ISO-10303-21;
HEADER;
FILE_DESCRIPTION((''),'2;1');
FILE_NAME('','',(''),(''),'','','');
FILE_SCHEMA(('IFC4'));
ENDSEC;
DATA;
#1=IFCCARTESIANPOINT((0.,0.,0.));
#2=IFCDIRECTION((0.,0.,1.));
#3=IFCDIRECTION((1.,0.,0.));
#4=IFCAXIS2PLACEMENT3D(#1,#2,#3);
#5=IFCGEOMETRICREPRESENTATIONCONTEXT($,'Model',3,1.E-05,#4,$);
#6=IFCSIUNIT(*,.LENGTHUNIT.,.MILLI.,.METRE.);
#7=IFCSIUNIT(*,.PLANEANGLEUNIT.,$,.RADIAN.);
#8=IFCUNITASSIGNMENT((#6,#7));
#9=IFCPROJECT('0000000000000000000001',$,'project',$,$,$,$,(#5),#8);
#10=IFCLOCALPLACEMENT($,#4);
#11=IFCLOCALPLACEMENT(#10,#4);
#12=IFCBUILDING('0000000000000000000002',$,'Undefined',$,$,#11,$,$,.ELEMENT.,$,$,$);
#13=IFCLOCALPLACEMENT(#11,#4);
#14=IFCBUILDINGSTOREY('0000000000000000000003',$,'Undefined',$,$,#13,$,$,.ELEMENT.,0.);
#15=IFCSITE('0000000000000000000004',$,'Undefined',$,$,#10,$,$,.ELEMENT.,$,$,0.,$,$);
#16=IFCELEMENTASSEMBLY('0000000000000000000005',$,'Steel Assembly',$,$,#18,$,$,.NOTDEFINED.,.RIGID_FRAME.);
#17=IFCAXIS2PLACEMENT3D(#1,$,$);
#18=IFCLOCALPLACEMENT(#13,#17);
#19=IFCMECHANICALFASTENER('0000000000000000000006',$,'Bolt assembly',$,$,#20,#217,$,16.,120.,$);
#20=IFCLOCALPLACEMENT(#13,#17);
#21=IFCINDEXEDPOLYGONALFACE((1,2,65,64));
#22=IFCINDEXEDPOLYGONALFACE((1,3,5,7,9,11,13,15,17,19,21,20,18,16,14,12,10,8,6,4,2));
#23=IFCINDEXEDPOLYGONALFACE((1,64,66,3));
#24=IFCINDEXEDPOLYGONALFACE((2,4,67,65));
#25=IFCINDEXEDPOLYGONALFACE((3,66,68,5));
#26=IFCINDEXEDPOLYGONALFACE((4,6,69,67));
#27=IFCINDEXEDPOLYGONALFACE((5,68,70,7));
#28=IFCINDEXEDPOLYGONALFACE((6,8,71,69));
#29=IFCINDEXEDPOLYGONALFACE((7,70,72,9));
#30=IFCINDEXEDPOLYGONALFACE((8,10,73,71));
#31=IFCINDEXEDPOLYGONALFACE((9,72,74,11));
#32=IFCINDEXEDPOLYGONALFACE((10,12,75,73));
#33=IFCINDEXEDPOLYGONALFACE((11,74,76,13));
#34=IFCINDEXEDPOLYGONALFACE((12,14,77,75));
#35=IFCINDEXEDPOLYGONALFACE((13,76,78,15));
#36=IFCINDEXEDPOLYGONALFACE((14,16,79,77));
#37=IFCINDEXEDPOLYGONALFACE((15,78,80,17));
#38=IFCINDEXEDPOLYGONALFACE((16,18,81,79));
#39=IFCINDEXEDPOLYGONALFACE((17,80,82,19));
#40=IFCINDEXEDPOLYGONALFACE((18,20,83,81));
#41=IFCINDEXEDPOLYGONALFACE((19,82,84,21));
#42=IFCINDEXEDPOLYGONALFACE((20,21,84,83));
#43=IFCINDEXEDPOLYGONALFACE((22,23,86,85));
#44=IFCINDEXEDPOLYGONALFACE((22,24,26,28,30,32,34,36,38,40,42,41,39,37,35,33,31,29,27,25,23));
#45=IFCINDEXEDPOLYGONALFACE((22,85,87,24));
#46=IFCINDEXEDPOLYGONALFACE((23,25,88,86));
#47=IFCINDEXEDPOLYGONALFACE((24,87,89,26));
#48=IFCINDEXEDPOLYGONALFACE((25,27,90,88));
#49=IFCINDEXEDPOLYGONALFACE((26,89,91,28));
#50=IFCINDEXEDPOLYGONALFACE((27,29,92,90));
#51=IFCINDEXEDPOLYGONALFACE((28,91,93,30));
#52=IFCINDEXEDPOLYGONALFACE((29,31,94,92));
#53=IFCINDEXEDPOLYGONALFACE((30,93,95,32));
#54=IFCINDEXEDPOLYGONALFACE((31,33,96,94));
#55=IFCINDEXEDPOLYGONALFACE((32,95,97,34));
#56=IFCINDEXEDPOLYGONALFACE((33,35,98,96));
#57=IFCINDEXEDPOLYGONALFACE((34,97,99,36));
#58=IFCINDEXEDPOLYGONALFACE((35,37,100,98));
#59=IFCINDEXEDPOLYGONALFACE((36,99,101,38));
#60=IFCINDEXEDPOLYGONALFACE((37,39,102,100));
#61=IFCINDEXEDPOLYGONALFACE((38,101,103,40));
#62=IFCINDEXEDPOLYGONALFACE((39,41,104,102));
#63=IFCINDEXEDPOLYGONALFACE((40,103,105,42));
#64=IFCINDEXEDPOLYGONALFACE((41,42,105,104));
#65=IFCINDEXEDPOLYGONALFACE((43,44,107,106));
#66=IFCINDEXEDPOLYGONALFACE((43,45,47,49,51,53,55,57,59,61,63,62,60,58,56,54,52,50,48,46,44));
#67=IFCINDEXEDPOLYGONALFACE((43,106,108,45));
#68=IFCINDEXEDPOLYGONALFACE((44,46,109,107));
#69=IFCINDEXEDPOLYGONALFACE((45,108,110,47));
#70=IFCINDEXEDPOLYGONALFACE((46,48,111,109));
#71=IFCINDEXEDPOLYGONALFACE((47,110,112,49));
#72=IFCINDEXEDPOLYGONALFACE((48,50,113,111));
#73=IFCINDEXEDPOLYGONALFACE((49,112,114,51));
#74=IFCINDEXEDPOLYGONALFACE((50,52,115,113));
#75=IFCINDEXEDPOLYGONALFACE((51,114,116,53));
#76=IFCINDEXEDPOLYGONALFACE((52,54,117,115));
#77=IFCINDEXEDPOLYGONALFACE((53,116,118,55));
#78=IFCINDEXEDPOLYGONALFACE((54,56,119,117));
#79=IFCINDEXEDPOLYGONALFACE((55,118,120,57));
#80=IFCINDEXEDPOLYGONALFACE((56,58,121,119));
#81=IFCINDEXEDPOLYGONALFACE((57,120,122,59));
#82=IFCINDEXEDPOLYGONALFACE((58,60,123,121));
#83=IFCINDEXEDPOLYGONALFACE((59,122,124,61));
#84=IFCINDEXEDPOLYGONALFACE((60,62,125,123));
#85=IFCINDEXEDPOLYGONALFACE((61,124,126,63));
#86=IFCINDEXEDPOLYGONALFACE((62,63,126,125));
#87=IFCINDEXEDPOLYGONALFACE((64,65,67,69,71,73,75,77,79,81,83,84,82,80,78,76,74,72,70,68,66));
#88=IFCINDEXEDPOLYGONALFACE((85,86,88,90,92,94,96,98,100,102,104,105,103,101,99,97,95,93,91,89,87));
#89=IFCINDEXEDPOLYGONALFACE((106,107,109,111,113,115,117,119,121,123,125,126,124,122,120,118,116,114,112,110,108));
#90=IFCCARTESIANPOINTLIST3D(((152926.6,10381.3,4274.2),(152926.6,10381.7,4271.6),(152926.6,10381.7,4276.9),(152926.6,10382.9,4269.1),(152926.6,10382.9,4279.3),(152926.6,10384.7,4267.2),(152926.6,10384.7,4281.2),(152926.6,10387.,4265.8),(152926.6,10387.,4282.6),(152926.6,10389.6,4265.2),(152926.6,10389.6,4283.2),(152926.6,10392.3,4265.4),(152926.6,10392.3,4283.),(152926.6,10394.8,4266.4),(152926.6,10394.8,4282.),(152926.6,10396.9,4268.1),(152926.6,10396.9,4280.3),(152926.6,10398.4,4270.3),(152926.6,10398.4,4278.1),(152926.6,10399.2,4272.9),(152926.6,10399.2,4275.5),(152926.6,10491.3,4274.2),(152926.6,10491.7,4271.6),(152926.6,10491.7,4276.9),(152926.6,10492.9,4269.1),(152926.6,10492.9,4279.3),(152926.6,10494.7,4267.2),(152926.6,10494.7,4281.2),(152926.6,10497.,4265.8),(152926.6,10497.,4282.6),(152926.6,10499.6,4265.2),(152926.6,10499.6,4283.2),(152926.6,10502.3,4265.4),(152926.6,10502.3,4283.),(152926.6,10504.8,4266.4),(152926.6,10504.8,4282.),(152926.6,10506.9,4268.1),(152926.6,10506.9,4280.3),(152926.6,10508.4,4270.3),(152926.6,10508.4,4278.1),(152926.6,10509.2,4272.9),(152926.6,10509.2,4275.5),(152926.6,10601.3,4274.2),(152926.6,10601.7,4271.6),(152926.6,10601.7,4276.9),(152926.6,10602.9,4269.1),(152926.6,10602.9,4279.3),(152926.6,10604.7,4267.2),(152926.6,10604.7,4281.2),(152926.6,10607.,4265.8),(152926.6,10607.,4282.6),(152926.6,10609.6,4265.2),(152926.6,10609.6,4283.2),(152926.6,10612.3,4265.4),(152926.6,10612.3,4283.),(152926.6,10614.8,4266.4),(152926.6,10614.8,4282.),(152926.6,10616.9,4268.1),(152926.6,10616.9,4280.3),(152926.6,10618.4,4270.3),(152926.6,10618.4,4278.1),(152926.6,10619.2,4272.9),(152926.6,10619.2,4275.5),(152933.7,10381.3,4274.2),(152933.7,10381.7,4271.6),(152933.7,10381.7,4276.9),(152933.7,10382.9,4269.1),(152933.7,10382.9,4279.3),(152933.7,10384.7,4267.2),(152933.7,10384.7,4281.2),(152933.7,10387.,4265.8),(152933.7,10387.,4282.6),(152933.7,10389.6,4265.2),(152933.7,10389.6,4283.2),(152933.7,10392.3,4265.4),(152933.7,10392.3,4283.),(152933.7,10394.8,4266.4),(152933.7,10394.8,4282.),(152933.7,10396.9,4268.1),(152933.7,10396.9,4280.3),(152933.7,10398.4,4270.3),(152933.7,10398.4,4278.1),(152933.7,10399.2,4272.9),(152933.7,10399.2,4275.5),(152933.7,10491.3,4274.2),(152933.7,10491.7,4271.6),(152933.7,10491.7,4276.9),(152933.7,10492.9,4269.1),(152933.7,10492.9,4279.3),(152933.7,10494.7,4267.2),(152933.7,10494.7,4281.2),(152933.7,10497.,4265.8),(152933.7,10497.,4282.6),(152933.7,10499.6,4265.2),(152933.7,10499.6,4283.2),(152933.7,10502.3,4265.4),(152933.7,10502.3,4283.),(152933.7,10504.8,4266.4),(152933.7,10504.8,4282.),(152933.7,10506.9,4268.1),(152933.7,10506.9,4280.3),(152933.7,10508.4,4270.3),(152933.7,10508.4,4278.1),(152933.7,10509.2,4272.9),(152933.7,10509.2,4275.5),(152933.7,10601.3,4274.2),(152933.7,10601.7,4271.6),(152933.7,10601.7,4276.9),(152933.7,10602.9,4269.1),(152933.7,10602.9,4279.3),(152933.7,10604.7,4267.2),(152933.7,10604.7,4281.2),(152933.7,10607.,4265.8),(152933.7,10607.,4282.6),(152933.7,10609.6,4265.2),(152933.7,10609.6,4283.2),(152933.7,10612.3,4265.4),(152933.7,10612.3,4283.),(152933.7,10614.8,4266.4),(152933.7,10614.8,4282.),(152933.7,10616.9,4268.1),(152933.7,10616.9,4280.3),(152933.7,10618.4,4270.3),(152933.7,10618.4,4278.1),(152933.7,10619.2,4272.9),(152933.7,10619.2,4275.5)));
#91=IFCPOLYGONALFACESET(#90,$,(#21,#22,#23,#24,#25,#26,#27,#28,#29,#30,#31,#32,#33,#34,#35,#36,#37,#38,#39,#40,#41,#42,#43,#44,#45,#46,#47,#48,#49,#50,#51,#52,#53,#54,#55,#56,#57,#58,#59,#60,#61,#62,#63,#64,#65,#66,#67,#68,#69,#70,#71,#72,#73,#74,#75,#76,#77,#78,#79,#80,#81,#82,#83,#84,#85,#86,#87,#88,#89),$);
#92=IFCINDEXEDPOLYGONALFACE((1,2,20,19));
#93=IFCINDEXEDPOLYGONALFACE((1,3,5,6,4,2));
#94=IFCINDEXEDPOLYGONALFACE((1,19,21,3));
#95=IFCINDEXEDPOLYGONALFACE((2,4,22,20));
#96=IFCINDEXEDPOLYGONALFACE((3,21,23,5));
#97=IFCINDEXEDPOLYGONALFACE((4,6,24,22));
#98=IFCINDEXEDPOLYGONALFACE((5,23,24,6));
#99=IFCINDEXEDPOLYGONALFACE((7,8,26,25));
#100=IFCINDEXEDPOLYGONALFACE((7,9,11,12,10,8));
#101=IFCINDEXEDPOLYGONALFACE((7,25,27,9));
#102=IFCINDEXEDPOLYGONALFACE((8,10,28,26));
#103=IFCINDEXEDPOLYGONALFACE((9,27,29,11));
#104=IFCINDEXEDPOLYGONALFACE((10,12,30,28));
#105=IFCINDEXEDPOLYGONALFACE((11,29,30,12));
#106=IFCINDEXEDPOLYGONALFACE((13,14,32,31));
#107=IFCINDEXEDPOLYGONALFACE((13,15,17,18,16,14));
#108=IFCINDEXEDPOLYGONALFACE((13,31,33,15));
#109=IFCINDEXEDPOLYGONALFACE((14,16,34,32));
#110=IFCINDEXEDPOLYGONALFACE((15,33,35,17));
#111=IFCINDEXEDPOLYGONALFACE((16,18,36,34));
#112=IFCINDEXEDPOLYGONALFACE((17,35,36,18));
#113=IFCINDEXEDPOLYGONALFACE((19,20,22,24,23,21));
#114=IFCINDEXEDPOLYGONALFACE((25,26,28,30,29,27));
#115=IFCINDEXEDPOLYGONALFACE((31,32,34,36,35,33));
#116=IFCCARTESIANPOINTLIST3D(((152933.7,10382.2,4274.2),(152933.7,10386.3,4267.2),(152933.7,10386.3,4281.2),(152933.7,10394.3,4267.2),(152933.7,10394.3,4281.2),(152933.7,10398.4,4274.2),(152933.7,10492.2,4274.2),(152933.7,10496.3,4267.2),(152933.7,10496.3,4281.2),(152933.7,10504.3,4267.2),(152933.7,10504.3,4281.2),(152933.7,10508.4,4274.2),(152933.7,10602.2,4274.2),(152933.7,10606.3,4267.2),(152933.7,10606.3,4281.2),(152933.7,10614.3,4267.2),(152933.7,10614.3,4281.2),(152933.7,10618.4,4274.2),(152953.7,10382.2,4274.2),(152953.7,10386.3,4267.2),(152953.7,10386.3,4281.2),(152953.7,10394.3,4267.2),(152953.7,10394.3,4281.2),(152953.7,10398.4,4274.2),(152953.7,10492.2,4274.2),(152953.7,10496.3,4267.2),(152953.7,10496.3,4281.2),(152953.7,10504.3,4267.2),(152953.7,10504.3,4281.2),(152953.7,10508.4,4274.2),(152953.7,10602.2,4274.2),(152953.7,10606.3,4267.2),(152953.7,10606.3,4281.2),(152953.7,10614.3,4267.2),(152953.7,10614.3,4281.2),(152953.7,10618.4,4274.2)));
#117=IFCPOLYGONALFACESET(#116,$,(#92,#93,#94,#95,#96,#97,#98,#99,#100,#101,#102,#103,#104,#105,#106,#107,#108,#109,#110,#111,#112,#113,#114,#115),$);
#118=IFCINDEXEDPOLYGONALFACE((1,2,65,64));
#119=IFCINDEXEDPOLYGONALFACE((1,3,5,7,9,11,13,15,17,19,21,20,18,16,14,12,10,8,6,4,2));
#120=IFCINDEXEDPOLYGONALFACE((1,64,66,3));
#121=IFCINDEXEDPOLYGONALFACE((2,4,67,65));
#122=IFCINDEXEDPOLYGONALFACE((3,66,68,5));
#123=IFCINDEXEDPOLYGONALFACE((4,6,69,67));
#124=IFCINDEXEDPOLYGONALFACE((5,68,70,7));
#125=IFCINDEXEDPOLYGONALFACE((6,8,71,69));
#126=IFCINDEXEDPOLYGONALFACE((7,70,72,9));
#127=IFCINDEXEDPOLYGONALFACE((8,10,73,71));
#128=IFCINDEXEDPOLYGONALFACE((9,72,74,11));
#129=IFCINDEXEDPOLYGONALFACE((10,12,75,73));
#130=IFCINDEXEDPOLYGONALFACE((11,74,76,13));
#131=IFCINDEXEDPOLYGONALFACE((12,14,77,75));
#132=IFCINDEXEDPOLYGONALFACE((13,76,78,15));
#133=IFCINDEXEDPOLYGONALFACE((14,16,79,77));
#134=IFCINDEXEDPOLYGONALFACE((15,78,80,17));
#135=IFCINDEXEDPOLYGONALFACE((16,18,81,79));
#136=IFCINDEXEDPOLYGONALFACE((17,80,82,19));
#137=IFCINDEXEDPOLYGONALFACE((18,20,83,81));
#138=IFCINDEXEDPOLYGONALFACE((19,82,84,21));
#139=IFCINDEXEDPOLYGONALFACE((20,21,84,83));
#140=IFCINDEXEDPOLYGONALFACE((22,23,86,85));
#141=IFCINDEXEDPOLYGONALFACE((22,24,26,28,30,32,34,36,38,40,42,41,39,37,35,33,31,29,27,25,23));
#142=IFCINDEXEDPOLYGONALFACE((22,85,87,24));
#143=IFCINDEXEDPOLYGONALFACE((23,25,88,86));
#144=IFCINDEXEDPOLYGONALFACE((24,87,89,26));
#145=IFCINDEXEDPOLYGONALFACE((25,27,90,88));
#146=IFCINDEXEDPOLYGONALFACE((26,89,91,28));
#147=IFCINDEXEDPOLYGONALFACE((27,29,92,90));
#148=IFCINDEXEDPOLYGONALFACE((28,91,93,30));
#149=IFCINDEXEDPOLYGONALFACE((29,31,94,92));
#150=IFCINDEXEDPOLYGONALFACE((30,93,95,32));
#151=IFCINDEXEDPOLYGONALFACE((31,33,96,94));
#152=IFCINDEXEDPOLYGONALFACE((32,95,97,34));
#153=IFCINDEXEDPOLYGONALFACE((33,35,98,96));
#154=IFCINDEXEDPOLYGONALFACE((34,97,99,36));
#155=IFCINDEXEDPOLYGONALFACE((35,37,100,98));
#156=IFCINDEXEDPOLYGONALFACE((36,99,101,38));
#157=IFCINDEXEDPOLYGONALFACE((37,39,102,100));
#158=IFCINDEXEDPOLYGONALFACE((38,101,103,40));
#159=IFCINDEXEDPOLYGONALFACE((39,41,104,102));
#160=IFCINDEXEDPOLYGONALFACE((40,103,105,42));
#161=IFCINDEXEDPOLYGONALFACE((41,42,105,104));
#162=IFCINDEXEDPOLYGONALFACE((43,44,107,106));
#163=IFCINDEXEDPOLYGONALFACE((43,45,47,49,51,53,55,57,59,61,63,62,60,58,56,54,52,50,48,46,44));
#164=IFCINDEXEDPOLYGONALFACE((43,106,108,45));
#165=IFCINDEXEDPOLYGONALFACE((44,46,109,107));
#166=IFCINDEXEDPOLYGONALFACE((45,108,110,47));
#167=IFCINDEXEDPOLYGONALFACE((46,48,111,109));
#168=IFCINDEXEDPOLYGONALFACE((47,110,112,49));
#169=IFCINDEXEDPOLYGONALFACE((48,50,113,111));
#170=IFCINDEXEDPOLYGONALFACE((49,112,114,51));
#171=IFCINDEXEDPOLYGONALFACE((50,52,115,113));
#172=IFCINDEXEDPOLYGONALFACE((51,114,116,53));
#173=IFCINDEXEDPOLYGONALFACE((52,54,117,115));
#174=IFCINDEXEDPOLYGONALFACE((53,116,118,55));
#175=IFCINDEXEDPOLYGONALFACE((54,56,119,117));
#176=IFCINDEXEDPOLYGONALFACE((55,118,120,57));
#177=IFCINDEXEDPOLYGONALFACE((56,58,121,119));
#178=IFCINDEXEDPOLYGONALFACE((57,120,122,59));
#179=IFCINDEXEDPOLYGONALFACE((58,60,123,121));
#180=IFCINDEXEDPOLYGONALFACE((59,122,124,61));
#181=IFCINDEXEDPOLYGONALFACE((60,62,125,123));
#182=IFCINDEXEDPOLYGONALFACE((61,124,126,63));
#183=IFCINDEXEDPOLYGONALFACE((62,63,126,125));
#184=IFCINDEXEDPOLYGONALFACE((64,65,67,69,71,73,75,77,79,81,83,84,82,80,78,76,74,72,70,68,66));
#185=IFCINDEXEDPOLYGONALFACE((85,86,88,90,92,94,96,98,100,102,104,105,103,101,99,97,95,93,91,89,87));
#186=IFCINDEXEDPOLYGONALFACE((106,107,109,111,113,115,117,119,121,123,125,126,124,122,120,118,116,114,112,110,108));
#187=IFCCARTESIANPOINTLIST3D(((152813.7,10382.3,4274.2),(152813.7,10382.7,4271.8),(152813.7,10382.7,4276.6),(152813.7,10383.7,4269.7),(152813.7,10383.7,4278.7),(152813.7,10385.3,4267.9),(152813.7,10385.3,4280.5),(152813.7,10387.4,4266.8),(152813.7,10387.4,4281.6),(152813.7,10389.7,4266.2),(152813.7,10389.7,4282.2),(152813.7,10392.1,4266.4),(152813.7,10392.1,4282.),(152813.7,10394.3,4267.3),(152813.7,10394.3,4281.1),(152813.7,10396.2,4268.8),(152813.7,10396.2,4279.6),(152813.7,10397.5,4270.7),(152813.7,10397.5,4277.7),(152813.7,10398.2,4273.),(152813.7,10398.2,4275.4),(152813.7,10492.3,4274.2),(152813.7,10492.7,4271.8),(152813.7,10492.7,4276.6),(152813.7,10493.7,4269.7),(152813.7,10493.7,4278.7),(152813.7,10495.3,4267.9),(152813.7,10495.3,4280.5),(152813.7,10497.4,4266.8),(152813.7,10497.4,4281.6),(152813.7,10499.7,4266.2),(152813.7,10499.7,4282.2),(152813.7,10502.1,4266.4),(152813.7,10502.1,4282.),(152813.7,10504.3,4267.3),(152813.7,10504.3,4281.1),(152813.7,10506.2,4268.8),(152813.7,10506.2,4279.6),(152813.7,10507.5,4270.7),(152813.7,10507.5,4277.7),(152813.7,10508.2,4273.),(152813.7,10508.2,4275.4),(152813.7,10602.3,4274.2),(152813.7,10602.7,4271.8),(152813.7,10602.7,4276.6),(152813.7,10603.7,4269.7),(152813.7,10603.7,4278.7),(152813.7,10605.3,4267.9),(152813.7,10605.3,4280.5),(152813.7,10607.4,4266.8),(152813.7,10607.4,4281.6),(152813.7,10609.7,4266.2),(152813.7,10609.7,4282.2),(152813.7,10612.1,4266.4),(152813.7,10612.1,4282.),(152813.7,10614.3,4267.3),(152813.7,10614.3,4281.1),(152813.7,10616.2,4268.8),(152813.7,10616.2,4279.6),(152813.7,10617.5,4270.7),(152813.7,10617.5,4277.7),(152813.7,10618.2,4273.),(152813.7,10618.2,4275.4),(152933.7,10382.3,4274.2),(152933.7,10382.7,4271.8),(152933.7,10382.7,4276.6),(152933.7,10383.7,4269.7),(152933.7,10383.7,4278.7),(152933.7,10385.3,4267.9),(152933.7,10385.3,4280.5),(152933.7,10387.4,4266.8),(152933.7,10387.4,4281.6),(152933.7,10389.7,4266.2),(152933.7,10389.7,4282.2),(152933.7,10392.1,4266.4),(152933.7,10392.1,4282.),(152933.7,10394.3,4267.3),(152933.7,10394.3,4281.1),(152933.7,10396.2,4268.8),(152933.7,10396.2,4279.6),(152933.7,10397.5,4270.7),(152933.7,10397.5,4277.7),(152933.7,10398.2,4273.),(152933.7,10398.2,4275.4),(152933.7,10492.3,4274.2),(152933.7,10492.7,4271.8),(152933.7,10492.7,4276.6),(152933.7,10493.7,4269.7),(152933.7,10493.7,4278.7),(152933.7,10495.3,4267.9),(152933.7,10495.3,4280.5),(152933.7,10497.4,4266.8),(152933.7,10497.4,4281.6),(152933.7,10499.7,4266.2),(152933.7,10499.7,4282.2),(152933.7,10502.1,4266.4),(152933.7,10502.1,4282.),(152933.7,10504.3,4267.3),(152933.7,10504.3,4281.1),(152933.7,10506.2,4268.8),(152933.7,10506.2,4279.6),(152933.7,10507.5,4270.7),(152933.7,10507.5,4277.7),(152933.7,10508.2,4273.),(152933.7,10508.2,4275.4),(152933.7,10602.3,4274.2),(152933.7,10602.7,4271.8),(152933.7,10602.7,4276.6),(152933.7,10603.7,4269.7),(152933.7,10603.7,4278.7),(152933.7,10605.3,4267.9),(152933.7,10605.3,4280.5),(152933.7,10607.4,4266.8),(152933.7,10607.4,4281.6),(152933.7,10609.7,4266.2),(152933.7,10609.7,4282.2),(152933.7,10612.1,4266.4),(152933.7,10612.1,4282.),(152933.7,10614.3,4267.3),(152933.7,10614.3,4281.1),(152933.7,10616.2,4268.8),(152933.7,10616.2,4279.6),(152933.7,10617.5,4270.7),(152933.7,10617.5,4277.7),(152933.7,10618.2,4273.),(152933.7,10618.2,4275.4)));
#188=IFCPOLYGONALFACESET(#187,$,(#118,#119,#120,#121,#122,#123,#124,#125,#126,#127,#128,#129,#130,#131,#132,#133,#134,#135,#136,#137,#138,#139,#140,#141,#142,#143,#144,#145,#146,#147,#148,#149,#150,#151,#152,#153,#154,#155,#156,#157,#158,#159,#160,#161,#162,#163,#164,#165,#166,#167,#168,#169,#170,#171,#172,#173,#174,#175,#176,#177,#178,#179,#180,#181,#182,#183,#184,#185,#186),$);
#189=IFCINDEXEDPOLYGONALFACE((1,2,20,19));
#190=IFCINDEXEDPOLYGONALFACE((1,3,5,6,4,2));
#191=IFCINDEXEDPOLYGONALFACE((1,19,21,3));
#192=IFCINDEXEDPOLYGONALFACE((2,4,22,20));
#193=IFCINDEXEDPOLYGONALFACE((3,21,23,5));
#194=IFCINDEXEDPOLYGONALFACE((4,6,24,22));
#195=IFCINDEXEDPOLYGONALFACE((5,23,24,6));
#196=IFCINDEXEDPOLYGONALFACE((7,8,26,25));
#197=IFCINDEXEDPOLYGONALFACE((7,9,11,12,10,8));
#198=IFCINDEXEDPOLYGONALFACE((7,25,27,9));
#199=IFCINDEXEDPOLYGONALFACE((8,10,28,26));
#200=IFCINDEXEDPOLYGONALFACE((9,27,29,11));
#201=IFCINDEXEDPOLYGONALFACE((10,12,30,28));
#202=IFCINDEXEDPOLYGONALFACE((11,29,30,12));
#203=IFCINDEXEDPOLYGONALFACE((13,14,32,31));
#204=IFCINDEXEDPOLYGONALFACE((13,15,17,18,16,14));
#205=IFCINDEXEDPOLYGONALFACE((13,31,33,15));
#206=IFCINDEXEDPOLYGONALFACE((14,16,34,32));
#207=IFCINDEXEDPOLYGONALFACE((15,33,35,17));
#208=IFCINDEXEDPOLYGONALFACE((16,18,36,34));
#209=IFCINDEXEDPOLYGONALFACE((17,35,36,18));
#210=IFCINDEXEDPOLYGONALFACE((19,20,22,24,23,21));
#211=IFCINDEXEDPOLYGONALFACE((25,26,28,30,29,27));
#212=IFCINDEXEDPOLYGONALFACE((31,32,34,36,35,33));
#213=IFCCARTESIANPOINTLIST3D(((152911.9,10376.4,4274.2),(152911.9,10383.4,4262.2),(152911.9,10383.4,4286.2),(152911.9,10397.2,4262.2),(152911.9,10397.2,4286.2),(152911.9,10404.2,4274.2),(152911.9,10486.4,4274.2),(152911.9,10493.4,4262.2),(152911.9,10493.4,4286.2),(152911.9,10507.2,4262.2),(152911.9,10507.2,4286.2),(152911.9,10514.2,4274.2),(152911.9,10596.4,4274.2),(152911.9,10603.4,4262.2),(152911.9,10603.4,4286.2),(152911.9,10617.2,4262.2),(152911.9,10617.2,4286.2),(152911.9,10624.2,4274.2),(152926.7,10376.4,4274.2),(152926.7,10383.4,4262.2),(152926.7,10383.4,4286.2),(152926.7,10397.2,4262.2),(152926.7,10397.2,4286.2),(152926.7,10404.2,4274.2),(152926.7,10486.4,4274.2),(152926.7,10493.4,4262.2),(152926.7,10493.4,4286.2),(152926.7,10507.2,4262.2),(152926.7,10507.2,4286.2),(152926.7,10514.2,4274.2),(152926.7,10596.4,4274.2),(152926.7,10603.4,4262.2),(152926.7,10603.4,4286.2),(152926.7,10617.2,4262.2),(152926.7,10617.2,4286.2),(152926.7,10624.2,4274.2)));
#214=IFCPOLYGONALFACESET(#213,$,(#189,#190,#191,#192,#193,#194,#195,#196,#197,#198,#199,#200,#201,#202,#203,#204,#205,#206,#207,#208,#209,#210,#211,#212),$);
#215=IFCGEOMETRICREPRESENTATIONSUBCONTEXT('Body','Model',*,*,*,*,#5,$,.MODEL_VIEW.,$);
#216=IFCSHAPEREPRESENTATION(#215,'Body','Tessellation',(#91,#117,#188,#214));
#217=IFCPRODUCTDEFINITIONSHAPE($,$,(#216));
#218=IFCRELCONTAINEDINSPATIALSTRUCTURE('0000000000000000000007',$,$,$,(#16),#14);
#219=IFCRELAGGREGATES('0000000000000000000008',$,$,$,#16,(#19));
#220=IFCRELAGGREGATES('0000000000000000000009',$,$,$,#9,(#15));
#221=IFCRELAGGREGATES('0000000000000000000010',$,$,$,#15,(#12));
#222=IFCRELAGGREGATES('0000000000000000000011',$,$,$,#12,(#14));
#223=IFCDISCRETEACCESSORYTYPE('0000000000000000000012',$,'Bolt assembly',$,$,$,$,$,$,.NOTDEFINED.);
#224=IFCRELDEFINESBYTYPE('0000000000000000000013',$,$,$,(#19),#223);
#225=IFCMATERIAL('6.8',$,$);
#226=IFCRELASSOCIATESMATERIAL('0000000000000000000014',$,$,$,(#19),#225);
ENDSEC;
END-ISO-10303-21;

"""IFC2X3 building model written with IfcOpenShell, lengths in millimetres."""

from ifc_helpers import new_model, si_unit, frame, origin_with_axes, origin_2d_with_axis, place, context, subcontext, project, spatial, polyline, circle, outline, extrude, source, transform, mapped, material, type_object, element, aggregate, save


model = new_model("IFC2X3")

# Units and contexts
model_context = context("Model", 3, precision=1e-05, world=origin_with_axes())
body_context = subcontext(model_context, "Body", "Model", "MODEL_VIEW")
ifc_project = project(units=[si_unit("LENGTHUNIT", "METRE", prefix="MILLI"), si_unit("PLANEANGLEUNIT", "RADIAN")], contexts=[model_context])

# Site, building, storey
site_placement = place(None, origin_with_axes())
site = spatial("IfcSite", under=ifc_project, at=site_placement, Name="Undefined", CompositionType="ELEMENT", RefElevation=0.0)
building_placement = place(site_placement, origin_with_axes())
building = spatial("IfcBuilding", under=site, at=building_placement, Name="Undefined", CompositionType="ELEMENT")
storey_placement = place(building_placement, origin_with_axes())
storey = spatial("IfcBuildingStorey", under=building, at=storey_placement, Name="Undefined", CompositionType="ELEMENT", Elevation=0.0)

# Element assembly
assembly_1_placement = place(storey_placement, origin_with_axes())
assembly_1 = element("IfcElementAssembly", 1, at=assembly_1_placement, inside=storey, Name="Steel Assembly", AssemblyPlace="NOTDEFINED", PredefinedType="RIGID_FRAME")

# Mechanical fastener
discrete_accessory_type_1 = type_object("IfcDiscreteAccessoryType", Name="Bolt assembly")
ifc_material_1 = material(Name="6.8")
shared_shape_1 = source(origin_with_axes(), body_context, "Body", "SweptSolid", [
    extrude(circle(Radius=9.0, at=origin_2d_with_axis()), frame((0.0, -2.5, 0.0), z_axis=(0.0, 1.0, 0.0), x_axis=(1.0, 0.0, 0.0)), (0.0, 0.0, 1.0), 7.1),
    extrude(outline(polyline([(8.1, 0.0), (4.0, 7.0), (-4.0, 7.0), (-8.1, 0.0), (-4.0, -7.0), (4.0, -7.0), (8.1, 0.0)])), frame((0.0, -22.5, 0.0), z_axis=(0.0, 1.0, 0.0), x_axis=(1.0, 0.0, 0.0)), (0.0, 0.0, 1.0), 20.0),
    extrude(circle(Radius=8.0, at=origin_2d_with_axis()), frame((0.0, -2.5, 0.0), z_axis=(0.0, 1.0, 0.0), x_axis=(1.0, 0.0, 0.0)), (0.0, 0.0, 1.0), 120.0),
    extrude(outline(polyline([(13.9, 0.0), (6.9, 12.0), (-6.9, 12.0), (-13.9, 0.0), (-6.9, -12.0), (6.9, -12.0), (13.9, 0.0)])), frame((0.0, 4.5, 0.0), z_axis=(0.0, 1.0, 0.0), x_axis=(1.0, 0.0, 0.0)), (0.0, 0.0, 1.0), 14.8),
])
mechanical_fastener_1_placement = place(assembly_1_placement, frame((152931.2, 10610.3, 4274.2), z_axis=(0.0, 0.0, -1.0), x_axis=(0.0, -1.0, 0.0)))
mechanical_fastener_1 = element("IfcMechanicalFastener", 2, at=mechanical_fastener_1_placement, type_object=discrete_accessory_type_1, material=ifc_material_1, Name="Bolt assembly", NominalDiameter=16.0, NominalLength=120.0, context=body_context, shape_type="MappedRepresentation", body=[
    mapped(shared_shape_1, transform((0.0, 0.0, 0.0))),
    mapped(shared_shape_1, transform((110.0, 0.0, 0.0))),
    mapped(shared_shape_1, transform((220.0, 0.0, 0.0))),
])
aggregate(assembly_1, [mechanical_fastener_1])

save(model, "model.ifc")
